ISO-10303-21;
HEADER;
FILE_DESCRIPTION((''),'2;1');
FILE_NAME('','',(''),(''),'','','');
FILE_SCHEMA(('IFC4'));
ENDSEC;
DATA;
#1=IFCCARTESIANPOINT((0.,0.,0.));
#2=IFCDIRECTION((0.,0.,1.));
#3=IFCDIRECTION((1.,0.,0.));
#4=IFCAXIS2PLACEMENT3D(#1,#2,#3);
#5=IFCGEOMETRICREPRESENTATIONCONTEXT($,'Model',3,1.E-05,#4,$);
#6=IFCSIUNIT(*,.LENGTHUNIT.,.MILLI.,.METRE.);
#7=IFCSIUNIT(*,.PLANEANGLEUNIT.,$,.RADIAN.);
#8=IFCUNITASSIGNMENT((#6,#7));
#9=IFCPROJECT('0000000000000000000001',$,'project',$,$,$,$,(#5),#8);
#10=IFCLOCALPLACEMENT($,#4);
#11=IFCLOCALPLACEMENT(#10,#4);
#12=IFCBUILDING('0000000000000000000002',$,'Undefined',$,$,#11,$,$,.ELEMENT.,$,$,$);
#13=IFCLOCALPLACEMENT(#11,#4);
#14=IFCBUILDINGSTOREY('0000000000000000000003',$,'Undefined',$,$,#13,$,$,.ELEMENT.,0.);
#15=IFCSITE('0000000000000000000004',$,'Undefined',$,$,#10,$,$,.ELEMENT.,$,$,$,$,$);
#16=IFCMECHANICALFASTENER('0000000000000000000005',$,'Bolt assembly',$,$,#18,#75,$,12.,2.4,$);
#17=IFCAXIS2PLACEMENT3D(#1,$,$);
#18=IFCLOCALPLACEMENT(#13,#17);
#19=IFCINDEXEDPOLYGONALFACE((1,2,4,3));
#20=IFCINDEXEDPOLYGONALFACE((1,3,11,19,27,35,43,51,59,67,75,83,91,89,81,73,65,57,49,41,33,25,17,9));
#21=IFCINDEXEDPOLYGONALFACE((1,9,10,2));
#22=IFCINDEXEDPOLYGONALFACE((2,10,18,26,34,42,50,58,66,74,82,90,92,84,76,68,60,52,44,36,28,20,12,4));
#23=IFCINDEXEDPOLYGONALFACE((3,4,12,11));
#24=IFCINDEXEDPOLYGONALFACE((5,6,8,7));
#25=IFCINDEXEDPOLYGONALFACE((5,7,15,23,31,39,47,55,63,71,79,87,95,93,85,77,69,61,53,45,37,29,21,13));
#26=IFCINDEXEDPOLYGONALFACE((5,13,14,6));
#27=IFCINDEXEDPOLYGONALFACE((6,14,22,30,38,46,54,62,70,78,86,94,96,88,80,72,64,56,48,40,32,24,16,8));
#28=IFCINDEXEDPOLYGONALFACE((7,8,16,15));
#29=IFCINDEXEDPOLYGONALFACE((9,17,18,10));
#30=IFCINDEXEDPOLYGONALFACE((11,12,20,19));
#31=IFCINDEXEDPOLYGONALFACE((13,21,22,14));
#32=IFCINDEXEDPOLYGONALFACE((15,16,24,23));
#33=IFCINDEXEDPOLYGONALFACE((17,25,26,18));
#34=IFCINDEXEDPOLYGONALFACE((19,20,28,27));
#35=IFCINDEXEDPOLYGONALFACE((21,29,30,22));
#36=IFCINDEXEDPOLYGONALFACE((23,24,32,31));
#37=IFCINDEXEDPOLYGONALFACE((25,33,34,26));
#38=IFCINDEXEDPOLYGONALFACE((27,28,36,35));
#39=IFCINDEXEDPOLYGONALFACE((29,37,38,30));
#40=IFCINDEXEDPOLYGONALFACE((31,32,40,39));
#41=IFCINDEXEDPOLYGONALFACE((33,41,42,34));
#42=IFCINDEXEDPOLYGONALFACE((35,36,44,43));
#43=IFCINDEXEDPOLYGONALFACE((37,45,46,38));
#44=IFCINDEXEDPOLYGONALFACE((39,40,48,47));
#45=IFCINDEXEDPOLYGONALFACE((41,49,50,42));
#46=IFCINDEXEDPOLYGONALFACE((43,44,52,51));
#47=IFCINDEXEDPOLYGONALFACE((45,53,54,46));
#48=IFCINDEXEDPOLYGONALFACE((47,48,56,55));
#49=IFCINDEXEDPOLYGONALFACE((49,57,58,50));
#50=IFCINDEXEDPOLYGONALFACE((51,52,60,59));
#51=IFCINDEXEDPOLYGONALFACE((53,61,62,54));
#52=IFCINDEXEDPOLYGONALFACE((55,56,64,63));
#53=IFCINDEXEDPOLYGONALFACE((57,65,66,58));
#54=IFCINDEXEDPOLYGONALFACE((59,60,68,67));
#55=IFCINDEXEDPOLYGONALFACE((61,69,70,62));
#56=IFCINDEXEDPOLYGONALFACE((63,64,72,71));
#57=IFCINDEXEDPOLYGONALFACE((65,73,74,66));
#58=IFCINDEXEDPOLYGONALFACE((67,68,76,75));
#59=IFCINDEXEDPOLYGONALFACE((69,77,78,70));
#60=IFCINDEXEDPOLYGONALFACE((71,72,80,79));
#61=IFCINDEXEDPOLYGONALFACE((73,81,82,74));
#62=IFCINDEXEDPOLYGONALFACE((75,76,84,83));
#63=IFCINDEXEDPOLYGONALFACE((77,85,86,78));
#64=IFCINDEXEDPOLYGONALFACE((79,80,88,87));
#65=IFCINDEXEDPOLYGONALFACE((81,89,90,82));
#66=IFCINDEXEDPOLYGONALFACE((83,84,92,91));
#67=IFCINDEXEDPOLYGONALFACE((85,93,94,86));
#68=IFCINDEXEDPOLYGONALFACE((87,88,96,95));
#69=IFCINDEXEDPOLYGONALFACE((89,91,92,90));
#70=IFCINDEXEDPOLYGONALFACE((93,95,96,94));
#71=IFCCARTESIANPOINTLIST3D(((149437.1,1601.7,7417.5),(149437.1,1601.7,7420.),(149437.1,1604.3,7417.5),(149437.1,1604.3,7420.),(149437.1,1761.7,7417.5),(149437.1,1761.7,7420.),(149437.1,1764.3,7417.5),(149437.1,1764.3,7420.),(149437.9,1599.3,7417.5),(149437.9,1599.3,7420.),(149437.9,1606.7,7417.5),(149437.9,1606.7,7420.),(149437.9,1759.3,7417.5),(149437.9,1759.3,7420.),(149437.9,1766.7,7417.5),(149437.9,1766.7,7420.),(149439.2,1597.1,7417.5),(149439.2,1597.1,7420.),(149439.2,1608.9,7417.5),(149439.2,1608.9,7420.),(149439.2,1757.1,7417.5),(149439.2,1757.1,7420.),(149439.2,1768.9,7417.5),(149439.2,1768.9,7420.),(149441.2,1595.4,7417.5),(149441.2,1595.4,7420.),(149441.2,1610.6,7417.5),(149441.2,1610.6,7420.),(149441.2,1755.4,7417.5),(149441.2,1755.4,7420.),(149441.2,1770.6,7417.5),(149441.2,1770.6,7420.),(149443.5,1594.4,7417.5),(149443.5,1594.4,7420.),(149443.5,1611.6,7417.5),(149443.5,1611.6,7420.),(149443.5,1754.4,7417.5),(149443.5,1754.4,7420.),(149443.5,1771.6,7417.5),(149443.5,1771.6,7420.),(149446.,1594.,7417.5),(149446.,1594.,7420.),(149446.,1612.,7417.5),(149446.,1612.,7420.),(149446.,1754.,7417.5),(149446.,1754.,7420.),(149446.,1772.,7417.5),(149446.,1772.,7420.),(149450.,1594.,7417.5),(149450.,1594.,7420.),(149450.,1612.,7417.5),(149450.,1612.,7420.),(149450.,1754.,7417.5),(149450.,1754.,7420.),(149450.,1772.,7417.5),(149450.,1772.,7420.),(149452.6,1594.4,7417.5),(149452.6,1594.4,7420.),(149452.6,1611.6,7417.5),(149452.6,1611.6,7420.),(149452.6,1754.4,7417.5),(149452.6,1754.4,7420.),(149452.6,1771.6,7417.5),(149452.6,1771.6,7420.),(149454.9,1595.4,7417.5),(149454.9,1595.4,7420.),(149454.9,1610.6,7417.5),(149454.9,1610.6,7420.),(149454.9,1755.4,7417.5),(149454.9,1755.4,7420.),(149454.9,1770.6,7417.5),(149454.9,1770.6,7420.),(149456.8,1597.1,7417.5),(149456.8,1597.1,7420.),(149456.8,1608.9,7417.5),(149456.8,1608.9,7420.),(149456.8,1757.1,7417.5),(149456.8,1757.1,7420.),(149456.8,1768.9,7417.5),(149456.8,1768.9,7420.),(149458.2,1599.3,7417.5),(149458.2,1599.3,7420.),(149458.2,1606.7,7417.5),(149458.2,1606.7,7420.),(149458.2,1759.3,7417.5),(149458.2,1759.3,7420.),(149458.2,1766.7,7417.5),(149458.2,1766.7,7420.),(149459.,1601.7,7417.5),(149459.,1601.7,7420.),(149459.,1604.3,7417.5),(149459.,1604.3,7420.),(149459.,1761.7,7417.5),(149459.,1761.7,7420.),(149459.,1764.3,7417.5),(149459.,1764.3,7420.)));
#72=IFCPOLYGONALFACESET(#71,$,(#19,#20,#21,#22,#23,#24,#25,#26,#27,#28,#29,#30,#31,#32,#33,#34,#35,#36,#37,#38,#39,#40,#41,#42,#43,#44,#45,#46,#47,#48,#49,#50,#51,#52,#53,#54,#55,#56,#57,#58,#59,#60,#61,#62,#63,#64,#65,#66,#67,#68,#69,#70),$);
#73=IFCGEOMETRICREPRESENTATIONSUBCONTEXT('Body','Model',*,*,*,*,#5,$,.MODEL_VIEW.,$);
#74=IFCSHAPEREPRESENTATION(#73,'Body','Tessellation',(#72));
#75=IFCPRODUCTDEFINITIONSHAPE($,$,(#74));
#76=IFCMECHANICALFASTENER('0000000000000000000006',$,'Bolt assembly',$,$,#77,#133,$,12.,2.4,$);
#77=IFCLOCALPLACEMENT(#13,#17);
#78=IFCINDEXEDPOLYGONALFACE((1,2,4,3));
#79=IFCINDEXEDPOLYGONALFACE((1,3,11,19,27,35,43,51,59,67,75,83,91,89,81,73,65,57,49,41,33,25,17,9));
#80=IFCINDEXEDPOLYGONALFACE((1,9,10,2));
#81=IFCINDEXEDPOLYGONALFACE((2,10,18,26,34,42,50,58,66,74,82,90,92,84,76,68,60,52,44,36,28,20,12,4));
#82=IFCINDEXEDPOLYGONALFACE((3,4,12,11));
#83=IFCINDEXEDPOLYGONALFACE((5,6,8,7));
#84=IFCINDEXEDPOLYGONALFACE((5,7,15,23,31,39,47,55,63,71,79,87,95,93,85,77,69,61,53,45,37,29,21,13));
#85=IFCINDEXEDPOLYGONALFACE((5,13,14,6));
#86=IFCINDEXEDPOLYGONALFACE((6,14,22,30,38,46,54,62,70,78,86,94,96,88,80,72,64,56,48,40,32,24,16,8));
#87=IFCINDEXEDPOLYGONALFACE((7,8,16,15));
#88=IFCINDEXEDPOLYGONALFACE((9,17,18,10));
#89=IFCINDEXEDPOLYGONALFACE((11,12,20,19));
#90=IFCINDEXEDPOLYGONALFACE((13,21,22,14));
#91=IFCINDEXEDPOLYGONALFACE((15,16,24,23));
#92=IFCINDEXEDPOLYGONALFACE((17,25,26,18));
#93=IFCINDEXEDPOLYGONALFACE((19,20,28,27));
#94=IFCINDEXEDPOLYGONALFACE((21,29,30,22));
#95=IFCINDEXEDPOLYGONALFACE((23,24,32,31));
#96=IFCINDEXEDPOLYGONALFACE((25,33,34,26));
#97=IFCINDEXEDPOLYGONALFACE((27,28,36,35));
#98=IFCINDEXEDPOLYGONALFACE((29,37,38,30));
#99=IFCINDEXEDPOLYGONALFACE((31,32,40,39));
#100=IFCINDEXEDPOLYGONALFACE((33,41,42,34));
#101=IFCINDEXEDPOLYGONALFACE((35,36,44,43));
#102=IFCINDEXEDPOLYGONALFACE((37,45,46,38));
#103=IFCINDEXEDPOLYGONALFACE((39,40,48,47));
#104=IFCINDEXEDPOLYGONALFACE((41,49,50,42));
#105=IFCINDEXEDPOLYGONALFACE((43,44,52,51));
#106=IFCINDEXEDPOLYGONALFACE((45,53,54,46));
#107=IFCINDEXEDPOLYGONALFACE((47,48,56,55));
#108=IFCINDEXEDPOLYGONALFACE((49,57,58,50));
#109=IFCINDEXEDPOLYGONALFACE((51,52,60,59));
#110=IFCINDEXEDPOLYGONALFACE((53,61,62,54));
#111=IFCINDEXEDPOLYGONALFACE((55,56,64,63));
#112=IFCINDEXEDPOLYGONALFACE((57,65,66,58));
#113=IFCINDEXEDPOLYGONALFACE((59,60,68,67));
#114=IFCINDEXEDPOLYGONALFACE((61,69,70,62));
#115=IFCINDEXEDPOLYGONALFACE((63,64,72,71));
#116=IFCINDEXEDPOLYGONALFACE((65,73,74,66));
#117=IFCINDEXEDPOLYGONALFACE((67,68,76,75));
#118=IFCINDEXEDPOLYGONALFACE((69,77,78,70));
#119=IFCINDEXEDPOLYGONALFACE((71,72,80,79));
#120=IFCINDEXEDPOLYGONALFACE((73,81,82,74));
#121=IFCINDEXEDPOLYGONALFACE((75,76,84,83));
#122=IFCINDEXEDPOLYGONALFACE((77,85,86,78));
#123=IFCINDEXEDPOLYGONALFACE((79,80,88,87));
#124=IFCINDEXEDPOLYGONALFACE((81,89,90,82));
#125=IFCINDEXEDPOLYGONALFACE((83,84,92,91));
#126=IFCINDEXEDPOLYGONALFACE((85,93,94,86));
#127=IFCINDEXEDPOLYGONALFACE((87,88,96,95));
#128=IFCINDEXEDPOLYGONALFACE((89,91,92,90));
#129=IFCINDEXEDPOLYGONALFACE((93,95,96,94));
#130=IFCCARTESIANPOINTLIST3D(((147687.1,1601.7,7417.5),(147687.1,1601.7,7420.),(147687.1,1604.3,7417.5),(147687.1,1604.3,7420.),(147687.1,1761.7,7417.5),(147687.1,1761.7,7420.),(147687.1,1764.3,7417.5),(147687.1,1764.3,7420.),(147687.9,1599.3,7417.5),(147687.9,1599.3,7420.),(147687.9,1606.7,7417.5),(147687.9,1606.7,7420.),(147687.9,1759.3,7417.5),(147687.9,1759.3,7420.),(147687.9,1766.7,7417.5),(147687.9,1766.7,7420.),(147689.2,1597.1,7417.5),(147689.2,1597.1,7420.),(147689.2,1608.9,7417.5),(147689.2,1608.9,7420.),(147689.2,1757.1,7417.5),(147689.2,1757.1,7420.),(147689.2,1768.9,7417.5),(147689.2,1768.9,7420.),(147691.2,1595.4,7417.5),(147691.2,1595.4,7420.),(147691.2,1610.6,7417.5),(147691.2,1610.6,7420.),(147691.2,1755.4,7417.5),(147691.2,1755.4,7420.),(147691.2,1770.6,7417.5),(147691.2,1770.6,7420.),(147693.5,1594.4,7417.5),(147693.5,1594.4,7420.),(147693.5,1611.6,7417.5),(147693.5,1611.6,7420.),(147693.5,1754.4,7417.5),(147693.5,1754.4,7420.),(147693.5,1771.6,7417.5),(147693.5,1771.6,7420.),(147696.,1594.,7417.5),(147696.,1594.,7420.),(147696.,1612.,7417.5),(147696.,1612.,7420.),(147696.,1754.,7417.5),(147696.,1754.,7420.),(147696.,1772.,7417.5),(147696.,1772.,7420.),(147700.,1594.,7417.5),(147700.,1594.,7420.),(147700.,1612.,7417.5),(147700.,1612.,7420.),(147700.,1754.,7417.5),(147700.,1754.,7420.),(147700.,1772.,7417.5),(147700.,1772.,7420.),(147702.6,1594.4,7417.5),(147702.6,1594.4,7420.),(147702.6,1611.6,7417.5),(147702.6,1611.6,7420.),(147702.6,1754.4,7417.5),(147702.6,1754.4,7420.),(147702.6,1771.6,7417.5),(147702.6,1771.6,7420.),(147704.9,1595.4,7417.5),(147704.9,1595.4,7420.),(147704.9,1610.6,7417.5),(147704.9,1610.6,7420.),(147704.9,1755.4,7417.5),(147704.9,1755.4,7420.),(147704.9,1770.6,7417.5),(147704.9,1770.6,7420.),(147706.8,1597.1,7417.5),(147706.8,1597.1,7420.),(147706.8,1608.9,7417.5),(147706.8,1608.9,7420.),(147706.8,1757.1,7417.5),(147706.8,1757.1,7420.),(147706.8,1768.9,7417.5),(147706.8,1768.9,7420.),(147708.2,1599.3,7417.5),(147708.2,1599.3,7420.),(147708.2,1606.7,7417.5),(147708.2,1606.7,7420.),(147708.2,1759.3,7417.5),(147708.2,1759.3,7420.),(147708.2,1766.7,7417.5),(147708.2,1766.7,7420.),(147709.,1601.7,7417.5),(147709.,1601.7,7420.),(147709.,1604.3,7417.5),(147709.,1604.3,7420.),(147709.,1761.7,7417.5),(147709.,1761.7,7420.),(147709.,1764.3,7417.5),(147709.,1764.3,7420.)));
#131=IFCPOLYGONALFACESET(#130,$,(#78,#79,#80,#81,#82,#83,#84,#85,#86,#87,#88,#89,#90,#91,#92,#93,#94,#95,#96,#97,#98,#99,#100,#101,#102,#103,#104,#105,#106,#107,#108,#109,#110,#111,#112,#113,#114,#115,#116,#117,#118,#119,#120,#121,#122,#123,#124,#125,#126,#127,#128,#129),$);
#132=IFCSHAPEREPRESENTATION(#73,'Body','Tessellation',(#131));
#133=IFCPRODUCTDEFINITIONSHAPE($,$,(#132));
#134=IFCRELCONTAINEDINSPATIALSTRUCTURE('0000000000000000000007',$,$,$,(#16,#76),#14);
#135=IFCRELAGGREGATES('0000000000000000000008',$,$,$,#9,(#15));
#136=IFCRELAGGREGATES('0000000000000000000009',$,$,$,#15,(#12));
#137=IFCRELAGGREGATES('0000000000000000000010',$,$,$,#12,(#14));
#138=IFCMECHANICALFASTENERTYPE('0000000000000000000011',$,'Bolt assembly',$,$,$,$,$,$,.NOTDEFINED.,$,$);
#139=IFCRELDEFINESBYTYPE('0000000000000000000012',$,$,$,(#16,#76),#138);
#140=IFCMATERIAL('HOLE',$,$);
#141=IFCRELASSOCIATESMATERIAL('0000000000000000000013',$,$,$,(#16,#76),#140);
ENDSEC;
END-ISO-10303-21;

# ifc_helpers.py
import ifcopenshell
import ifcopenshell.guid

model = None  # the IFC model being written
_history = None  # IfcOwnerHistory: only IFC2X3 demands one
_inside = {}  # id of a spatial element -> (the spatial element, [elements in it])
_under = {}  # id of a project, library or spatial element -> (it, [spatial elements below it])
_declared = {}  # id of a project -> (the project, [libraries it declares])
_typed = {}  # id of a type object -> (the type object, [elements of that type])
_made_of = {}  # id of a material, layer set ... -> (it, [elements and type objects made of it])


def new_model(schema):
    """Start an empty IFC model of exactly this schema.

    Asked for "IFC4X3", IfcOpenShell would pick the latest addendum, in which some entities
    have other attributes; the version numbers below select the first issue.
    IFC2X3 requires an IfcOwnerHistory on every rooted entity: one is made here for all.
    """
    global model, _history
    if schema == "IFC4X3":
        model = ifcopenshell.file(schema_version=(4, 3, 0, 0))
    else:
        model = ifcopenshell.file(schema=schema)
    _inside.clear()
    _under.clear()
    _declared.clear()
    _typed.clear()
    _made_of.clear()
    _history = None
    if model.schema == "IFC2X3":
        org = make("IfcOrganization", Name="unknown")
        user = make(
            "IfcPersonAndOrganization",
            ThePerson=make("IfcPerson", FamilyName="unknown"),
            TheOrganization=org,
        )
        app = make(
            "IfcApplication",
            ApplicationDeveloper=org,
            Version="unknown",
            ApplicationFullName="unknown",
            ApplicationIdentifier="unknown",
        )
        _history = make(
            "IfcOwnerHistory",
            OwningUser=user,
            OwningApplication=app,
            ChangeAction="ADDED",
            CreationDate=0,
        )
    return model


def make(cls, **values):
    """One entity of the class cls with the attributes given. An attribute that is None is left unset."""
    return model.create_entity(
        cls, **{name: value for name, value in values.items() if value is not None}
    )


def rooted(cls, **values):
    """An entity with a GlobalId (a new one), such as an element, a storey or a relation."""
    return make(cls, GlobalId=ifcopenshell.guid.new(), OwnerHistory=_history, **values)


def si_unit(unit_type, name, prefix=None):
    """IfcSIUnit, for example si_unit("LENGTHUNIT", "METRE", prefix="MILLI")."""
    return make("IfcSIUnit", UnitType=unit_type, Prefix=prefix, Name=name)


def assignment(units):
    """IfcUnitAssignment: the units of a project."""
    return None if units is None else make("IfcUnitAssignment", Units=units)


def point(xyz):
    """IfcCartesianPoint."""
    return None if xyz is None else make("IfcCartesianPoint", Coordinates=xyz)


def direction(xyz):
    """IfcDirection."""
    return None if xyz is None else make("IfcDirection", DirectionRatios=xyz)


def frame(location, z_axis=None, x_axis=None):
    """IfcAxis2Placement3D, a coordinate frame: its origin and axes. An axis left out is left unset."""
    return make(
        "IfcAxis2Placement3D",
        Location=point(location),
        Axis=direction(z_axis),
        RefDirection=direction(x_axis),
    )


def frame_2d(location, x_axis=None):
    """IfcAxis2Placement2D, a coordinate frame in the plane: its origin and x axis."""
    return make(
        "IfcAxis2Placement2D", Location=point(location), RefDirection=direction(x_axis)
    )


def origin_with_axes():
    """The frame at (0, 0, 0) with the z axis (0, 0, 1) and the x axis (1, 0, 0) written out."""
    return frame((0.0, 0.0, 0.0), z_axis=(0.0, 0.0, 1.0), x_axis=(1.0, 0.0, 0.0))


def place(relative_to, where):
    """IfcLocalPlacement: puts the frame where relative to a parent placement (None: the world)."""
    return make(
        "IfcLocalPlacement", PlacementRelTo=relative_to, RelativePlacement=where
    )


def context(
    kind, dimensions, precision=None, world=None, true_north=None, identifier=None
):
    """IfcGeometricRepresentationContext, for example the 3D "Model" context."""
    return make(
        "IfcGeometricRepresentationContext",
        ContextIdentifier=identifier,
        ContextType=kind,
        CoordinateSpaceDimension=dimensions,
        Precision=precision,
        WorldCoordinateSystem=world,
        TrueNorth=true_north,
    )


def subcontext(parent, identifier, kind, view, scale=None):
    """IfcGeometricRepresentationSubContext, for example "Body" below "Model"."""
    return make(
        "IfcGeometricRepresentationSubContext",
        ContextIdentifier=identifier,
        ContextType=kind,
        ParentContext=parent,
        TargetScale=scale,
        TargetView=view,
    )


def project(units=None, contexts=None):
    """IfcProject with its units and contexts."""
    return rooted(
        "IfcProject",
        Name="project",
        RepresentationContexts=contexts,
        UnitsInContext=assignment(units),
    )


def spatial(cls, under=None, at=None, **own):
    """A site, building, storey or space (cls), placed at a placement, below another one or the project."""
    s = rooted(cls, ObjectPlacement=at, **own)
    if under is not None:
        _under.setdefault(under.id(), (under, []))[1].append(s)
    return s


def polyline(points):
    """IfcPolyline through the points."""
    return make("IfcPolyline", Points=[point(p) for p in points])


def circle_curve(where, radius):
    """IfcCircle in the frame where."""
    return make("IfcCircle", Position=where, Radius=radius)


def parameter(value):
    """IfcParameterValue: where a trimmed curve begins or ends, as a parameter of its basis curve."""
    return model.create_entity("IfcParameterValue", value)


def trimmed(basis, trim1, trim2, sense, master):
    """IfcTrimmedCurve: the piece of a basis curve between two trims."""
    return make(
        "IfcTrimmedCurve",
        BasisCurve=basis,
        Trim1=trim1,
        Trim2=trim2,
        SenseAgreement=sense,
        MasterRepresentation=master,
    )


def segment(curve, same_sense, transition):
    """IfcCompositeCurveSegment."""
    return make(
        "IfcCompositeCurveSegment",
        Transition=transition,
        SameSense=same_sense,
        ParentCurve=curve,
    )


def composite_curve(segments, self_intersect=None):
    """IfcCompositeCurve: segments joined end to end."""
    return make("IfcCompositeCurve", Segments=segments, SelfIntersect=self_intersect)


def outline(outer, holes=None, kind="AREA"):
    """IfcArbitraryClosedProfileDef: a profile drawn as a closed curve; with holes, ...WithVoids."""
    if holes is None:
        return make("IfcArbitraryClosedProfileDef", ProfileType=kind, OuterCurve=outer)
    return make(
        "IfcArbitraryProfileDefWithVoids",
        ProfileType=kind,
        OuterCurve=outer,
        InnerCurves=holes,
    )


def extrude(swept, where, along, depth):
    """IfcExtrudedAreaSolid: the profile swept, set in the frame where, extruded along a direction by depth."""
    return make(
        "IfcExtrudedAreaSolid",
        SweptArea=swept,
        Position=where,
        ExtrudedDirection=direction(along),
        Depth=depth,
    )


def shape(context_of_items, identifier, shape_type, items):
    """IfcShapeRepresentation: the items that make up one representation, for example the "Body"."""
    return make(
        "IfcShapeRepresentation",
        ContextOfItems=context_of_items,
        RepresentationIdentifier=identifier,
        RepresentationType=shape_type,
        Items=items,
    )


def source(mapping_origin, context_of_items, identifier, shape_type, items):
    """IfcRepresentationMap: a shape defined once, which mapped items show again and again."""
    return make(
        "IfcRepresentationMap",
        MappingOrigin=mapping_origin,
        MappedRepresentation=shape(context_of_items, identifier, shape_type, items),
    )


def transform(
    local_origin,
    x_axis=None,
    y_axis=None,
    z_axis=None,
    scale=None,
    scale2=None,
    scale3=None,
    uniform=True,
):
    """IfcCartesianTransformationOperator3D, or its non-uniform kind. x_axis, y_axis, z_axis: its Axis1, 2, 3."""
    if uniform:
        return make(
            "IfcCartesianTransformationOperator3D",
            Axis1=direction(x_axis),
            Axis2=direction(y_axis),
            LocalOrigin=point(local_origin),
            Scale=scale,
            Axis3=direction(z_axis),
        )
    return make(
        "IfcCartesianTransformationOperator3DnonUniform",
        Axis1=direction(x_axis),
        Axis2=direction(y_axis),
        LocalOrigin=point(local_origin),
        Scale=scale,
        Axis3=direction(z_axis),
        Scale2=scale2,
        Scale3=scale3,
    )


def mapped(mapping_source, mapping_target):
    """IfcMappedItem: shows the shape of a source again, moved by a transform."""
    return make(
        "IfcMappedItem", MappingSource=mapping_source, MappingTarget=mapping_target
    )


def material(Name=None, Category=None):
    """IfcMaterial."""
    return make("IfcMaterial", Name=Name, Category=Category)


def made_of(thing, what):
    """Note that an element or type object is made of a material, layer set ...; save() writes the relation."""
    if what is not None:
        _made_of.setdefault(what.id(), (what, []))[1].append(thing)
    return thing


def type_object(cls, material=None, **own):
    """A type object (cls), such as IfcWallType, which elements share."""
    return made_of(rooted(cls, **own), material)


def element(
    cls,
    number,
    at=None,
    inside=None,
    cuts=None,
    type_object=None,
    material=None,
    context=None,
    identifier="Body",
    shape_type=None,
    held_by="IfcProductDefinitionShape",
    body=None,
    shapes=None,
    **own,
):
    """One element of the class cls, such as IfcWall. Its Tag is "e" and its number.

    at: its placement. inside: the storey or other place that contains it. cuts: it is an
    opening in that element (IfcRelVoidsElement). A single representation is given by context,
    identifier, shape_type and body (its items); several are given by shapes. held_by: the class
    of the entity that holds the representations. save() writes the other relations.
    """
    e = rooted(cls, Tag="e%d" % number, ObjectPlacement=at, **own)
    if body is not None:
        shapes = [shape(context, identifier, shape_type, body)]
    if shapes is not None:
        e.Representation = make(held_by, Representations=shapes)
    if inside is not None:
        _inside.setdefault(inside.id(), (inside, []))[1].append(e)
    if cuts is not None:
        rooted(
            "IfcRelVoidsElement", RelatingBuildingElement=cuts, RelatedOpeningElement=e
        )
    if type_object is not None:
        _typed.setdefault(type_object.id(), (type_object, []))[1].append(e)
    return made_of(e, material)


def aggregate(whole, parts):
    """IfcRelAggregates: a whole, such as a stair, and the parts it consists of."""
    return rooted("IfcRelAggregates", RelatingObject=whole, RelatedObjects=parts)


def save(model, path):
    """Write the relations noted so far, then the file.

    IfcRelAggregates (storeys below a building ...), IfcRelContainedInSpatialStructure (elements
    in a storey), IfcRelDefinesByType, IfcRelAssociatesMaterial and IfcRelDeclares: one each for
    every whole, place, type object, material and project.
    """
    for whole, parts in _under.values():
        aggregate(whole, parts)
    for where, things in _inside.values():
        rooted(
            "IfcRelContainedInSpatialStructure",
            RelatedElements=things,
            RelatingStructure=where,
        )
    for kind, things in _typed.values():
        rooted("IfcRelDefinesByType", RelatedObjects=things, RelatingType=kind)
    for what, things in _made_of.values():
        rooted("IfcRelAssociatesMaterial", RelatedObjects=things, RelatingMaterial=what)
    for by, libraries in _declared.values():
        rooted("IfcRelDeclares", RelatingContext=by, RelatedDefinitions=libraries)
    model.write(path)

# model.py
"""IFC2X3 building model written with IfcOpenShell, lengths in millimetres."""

from ifc_helpers import new_model, si_unit, frame, frame_2d, origin_with_axes, place, context, subcontext, project, spatial, polyline, circle_curve, parameter, trimmed, segment, composite_curve, outline, extrude, source, transform, mapped, material, type_object, element, save


model = new_model("IFC2X3")

# Units and contexts
model_context = context("Model", 3, precision=1e-05, world=origin_with_axes())
body_context = subcontext(model_context, "Body", "Model", "MODEL_VIEW")
ifc_project = project(units=[si_unit("LENGTHUNIT", "METRE", prefix="MILLI"), si_unit("PLANEANGLEUNIT", "RADIAN")], contexts=[model_context])

# Site, building, storey
site_placement = place(None, origin_with_axes())
site = spatial("IfcSite", under=ifc_project, at=site_placement, Name="Undefined", CompositionType="ELEMENT")
building_placement = place(site_placement, origin_with_axes())
building = spatial("IfcBuilding", under=site, at=building_placement, Name="Undefined", CompositionType="ELEMENT")
storey_placement = place(building_placement, origin_with_axes())
storey = spatial("IfcBuildingStorey", under=building, at=storey_placement, Name="Undefined", CompositionType="ELEMENT", Elevation=0.0)

# Mechanical fasteners
mechanical_fastener_type = type_object("IfcMechanicalFastenerType", Name="Bolt assembly")
ifc_material_1 = material(Name="HOLE")
shared_shape_1 = source(origin_with_axes(), body_context, "Body", "SweptSolid", [
    extrude(outline(composite_curve([segment(polyline([(-2.0, 9.0), (2.0, 9.0)]), True, "CONTINUOUS"), segment(trimmed(circle_curve(frame_2d((2.0, 0.0), x_axis=(0.0, 1.0)), 9.0), [parameter(0.0)], [parameter(3.141593)], False, "PARAMETER"), True, "CONTINUOUS"), segment(polyline([(2.0, -9.0), (-2.0, -9.0)]), True, "CONTINUOUS"), segment(trimmed(circle_curve(frame_2d((-2.0, 0.0), x_axis=(0.0, -1.0)), 9.0), [parameter(0.0)], [parameter(3.141593)], False, "PARAMETER"), True, "DISCONTINUOUS")], self_intersect=False)), frame((0.0, -2.4, 0.0), z_axis=(0.0, 1.0, 0.0), x_axis=(1.0, 0.0, 0.0)), (0.0, 0.0, 1.0), 2.5),
])
mechanical_fastener_1_placement = place(storey_placement, frame((149448.0, 1683.0, 7417.6), z_axis=(0.0, -1.0, 0.0), x_axis=(-1.0, 0.0, 0.0)))
element("IfcMechanicalFastener", 1, at=mechanical_fastener_1_placement, inside=storey, type_object=mechanical_fastener_type, material=ifc_material_1, Name="Bolt assembly", NominalDiameter=12.0, NominalLength=2.4, context=body_context, shape_type="MappedRepresentation", body=[
    mapped(shared_shape_1, transform((0.0, 0.0, -80.0))),
    mapped(shared_shape_1, transform((0.0, 0.0, 80.0))),
])
shared_shape_2 = source(origin_with_axes(), body_context, "Body", "SweptSolid", [
    extrude(outline(composite_curve([segment(polyline([(-2.0, 9.0), (2.0, 9.0)]), True, "CONTINUOUS"), segment(trimmed(circle_curve(frame_2d((2.0, 0.0), x_axis=(0.0, 1.0)), 9.0), [parameter(0.0)], [parameter(3.141593)], False, "PARAMETER"), True, "CONTINUOUS"), segment(polyline([(2.0, -9.0), (-2.0, -9.0)]), True, "CONTINUOUS"), segment(trimmed(circle_curve(frame_2d((-2.0, 0.0), x_axis=(0.0, -1.0)), 9.0), [parameter(0.0)], [parameter(3.141593)], False, "PARAMETER"), True, "DISCONTINUOUS")], self_intersect=False)), frame((0.0, -2.4, 0.0), z_axis=(0.0, 1.0, 0.0), x_axis=(1.0, 0.0, 0.0)), (0.0, 0.0, 1.0), 2.5),
])
mechanical_fastener_2_placement = place(storey_placement, frame((147698.0, 1683.0, 7417.6), z_axis=(0.0, -1.0, 0.0), x_axis=(-1.0, 0.0, 0.0)))
element("IfcMechanicalFastener", 2, at=mechanical_fastener_2_placement, inside=storey, type_object=mechanical_fastener_type, material=ifc_material_1, Name="Bolt assembly", NominalDiameter=12.0, NominalLength=2.4, context=body_context, shape_type="MappedRepresentation", body=[
    mapped(shared_shape_2, transform((0.0, 0.0, -80.0))),
    mapped(shared_shape_2, transform((0.0, 0.0, 80.0))),
])

save(model, "model.ifc")
